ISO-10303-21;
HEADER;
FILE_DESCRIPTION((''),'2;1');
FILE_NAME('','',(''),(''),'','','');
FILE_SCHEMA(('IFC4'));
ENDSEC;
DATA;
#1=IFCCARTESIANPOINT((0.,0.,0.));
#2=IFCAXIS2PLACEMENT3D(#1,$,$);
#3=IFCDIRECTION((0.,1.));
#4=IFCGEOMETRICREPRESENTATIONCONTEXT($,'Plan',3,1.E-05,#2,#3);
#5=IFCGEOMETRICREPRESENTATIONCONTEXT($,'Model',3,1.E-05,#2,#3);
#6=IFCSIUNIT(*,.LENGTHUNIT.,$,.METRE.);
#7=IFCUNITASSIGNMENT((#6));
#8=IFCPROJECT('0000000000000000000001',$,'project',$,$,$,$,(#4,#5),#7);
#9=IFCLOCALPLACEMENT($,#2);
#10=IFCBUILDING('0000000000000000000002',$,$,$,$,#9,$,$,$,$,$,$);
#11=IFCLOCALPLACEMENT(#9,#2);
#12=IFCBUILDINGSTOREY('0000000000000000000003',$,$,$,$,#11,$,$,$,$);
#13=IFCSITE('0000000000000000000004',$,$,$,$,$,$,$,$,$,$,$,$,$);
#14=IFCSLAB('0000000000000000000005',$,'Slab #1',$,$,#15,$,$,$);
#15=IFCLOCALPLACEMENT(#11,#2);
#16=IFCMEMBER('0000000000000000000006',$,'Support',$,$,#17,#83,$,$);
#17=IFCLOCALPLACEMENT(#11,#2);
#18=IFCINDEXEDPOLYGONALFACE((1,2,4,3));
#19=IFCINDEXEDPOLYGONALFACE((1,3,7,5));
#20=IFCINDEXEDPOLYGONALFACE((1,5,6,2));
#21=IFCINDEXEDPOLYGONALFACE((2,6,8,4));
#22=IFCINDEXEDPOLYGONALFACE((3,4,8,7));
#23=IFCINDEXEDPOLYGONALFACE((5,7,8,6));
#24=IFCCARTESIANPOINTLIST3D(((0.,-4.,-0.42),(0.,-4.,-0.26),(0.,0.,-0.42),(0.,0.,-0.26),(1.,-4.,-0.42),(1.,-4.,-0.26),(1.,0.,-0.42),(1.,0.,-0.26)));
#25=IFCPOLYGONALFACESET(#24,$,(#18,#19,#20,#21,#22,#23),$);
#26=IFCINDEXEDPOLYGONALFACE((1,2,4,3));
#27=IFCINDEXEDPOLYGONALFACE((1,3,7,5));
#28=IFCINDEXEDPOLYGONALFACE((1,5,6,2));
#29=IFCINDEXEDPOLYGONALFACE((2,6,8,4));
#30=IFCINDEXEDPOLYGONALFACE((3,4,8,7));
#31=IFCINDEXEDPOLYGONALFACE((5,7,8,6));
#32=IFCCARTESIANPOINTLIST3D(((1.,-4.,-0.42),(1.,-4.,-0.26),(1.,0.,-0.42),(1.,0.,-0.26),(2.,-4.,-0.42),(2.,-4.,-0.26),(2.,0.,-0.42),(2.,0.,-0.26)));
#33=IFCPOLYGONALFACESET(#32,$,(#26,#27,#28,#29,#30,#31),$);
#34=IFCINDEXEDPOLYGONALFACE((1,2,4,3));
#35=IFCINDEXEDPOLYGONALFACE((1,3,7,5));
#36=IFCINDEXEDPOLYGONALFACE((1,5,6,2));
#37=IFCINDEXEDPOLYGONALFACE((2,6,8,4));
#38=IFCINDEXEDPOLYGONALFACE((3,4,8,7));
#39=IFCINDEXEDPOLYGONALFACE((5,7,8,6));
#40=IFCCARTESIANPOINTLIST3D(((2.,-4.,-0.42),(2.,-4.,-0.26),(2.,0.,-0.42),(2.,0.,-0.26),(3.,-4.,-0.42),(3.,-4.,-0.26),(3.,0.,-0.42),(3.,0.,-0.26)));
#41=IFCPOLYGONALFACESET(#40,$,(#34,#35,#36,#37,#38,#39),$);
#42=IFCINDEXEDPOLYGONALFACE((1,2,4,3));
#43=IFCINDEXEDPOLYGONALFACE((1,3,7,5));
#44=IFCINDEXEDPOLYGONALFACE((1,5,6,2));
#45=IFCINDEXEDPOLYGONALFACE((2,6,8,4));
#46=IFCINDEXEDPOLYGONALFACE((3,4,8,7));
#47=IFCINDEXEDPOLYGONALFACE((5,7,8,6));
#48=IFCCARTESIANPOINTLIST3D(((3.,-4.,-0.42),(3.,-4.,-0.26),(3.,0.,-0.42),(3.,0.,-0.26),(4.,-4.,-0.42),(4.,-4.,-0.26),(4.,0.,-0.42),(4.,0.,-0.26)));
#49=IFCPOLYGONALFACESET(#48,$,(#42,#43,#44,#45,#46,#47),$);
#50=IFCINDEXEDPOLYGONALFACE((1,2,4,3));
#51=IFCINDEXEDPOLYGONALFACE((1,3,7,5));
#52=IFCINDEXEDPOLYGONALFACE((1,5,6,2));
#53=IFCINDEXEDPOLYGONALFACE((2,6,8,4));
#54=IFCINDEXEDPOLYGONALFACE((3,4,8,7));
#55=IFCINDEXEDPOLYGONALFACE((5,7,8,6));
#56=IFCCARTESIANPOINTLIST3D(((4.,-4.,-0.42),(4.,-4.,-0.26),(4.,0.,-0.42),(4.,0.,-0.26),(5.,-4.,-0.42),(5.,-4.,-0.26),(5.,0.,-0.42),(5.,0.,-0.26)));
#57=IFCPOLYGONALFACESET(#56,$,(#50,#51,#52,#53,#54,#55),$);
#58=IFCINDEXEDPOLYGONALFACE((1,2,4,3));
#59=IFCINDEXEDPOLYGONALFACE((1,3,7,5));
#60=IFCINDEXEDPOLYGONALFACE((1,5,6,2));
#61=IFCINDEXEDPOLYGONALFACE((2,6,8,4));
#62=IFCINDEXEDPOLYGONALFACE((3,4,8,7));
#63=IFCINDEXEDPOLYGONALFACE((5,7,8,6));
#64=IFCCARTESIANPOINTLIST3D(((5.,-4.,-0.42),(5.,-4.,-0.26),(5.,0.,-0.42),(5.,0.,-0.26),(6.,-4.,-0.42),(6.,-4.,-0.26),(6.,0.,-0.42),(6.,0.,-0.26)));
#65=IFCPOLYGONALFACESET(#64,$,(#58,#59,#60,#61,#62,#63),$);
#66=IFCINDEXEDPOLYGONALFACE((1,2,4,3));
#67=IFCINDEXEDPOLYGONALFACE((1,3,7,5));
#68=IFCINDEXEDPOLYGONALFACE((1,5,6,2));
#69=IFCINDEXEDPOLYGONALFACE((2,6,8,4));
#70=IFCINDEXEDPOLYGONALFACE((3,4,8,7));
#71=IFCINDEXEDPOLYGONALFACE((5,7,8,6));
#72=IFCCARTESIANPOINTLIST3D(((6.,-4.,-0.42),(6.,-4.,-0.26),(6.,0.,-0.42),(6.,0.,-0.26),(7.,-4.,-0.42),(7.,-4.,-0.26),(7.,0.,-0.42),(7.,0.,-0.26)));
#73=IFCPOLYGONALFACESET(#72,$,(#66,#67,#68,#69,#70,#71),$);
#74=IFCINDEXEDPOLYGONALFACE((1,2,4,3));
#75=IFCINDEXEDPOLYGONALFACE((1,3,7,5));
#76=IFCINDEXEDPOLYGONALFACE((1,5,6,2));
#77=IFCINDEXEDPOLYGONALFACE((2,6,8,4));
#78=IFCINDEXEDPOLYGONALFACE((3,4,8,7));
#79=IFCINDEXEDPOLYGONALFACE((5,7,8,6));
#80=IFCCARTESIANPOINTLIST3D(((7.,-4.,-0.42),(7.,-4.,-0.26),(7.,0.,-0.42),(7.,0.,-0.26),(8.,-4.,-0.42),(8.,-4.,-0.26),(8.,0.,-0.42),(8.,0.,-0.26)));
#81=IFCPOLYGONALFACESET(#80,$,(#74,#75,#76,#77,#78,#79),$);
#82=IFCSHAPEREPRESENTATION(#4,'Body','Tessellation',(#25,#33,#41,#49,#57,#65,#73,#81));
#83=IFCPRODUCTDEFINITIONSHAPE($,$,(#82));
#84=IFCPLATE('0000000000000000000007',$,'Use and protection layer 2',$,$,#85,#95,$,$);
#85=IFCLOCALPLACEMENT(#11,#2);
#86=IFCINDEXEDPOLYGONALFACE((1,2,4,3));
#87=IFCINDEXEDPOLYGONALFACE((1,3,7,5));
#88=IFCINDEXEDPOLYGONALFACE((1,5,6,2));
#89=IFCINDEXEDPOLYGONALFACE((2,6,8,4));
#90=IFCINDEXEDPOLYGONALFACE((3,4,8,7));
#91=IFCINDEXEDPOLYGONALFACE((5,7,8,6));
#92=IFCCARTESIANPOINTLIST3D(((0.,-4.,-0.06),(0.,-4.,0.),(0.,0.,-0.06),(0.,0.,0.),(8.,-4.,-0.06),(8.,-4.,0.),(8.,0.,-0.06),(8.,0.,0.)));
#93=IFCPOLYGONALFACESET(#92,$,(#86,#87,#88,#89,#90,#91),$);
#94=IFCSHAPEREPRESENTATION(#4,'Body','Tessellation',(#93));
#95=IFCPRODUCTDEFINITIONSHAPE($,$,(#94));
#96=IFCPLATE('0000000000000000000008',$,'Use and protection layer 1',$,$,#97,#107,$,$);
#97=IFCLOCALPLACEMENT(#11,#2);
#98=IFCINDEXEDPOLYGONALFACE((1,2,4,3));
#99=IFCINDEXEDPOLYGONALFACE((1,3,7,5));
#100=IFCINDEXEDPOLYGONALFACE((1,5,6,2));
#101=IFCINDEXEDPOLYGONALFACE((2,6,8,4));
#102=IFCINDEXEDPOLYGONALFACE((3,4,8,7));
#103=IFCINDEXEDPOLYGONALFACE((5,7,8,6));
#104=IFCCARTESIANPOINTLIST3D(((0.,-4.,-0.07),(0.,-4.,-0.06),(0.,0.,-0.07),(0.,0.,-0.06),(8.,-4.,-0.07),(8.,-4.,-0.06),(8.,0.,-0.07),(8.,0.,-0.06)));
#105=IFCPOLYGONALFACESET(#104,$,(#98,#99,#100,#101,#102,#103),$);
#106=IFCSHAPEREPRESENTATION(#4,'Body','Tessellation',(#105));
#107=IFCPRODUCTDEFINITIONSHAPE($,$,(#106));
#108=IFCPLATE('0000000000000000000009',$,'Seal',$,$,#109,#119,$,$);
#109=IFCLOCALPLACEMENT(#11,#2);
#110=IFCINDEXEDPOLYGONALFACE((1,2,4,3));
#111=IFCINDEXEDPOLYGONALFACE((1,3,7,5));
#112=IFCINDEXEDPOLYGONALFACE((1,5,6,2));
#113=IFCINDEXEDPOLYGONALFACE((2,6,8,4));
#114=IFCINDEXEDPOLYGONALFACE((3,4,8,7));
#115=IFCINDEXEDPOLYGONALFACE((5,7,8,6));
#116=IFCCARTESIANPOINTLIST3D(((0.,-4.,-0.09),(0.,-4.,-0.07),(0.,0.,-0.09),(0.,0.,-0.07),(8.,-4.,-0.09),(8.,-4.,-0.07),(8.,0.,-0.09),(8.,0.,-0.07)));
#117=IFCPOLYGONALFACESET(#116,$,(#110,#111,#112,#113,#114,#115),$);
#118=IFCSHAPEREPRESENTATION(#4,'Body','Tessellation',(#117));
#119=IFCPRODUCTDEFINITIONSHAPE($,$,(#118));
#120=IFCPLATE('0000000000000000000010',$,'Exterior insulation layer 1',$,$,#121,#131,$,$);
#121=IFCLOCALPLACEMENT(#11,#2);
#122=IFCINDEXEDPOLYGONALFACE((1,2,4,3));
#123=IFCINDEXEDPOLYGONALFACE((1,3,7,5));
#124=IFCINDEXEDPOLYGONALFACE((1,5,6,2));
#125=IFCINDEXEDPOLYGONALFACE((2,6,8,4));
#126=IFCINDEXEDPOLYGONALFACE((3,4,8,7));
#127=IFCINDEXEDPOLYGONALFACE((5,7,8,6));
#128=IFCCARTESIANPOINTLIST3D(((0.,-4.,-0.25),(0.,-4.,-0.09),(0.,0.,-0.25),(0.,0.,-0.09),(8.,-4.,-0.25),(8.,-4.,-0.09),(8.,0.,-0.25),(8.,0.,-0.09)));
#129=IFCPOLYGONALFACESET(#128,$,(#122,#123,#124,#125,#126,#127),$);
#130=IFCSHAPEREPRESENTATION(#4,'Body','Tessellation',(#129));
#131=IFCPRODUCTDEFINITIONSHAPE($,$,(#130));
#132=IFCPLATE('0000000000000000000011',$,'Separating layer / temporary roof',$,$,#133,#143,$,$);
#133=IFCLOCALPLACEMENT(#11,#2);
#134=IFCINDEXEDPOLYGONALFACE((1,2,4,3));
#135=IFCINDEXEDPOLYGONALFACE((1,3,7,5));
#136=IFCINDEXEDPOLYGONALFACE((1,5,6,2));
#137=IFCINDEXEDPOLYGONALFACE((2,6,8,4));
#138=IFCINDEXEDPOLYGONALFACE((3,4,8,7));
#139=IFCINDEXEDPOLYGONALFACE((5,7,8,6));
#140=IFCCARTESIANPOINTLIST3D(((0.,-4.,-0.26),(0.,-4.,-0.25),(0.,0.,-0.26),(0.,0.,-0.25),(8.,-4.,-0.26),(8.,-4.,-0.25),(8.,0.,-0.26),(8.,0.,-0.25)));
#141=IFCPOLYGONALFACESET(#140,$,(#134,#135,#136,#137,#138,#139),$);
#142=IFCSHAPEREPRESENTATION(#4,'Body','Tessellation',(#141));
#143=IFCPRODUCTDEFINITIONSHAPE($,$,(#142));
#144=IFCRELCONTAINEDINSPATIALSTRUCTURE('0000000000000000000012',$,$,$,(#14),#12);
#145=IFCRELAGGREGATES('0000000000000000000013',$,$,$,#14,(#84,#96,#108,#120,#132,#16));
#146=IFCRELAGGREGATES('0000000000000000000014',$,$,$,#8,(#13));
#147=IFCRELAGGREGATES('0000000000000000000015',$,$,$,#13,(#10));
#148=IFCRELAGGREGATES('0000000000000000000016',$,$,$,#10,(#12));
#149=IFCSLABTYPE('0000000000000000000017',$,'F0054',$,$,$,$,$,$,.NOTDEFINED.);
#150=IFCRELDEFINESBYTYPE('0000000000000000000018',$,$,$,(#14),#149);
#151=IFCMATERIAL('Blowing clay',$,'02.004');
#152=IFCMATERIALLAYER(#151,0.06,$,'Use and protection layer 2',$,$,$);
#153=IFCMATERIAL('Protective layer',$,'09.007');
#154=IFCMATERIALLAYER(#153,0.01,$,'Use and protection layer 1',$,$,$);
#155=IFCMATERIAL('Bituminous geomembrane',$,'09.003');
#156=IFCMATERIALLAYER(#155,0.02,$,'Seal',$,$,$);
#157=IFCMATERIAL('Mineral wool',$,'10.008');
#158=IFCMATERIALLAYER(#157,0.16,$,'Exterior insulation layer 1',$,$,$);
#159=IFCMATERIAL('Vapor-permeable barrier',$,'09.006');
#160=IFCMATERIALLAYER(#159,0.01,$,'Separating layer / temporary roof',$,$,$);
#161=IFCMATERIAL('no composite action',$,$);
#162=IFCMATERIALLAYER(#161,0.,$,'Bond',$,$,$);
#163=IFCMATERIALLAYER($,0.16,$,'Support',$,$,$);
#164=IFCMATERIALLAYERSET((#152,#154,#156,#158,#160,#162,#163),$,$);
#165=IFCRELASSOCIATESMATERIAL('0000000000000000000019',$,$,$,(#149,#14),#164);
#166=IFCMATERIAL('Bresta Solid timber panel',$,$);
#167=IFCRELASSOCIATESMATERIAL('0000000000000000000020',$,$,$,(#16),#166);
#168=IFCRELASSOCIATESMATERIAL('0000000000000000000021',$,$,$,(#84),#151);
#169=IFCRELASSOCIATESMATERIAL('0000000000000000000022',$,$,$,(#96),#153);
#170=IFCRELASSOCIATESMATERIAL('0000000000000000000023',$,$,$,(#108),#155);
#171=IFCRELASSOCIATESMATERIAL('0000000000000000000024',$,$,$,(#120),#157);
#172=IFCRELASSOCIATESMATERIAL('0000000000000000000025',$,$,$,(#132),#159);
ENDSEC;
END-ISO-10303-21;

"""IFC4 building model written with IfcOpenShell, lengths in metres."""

from ifc_helpers import new_model, si_unit, direction, frame, frame_2d, origin, origin_with_axes, place, context, project, spatial, rectangle, extrude, material, layer, layer_set, type_object, element, aggregate, save


model = new_model("IFC4")

# Units and contexts
plan_context = context("Plan", 3, precision=1e-05, world=origin(), true_north=direction((0.0, 1.0)))
model_context = context("Model", 3, precision=1e-05, world=origin(), true_north=direction((0.0, 1.0)))
ifc_project = project(units=[si_unit("LENGTHUNIT", "METRE")], contexts=[plan_context, model_context])

# Site, building, storey
site = spatial("IfcSite", under=ifc_project)
building_placement = place(None, origin())
building = spatial("IfcBuilding", under=site, at=building_placement)
storey_placement = place(building_placement, origin())
storey = spatial("IfcBuildingStorey", under=building, at=storey_placement)

# Slab, member, plates
ifc_material_1 = material(Name="Blowing clay", Category="02.004")
ifc_layer_1 = layer(ifc_material_1, 0.06, Name="Use and protection layer 2")
ifc_material_2 = material(Name="Protective layer", Category="09.007")
ifc_layer_2 = layer(ifc_material_2, 0.01, Name="Use and protection layer 1")
ifc_material_3 = material(Name="Bituminous geomembrane", Category="09.003")
ifc_layer_3 = layer(ifc_material_3, 0.02, Name="Seal")
ifc_material_4 = material(Name="Mineral wool", Category="10.008")
ifc_layer_4 = layer(ifc_material_4, 0.16, Name="Exterior insulation layer 1")
ifc_material_5 = material(Name="Vapor-permeable barrier", Category="09.006")
ifc_layer_5 = layer(ifc_material_5, 0.01, Name="Separating layer / temporary roof")
ifc_material_6 = material(Name="no composite action")
ifc_layer_6 = layer(ifc_material_6, 0.0, Name="Bond")
ifc_layer_7 = layer(None, 0.16, Name="Support")
ifc_layer_set = layer_set([ifc_layer_1, ifc_layer_2, ifc_layer_3, ifc_layer_4, ifc_layer_5, ifc_layer_6, ifc_layer_7])
slab_type = type_object("IfcSlabType", Name="F0054", PredefinedType="NOTDEFINED", material=ifc_layer_set)
slab_placement = place(None, frame((0.0, 0.0, 0.0), z_axis=(0.0, 0.0, -1.0), x_axis=(1.0, 0.0, 0.0)))
slab = element("IfcSlab", 1, at=slab_placement, inside=storey, type_object=slab_type, material=ifc_layer_set, Name="Slab #1")
ifc_material_7 = material(Name="Bresta Solid timber panel")
member_placement = place(slab_placement, origin())
member = element("IfcMember", 2, at=member_placement, material=ifc_material_7, Name="Support", context=plan_context, shape_type="SweptSolid", body=[
    extrude(rectangle(XDim=1.0, YDim=0.16, at=frame_2d((0.5, 0.08), x_axis=(1.0, 0.0))), frame((0.0, 4.0, 0.26), z_axis=(0.0, -1.0, 0.0), x_axis=(1.0, 0.0, 0.0)), (0.0, 0.0, 1.0), 4.0),
    extrude(rectangle(XDim=1.0, YDim=0.16, at=frame_2d((0.5, 0.08), x_axis=(1.0, 0.0))), frame((1.0, 4.0, 0.26), z_axis=(0.0, -1.0, 0.0), x_axis=(1.0, 0.0, 0.0)), (0.0, 0.0, 1.0), 4.0),
    extrude(rectangle(XDim=1.0, YDim=0.16, at=frame_2d((0.5, 0.08), x_axis=(1.0, 0.0))), frame((2.0, 4.0, 0.26), z_axis=(0.0, -1.0, 0.0), x_axis=(1.0, 0.0, 0.0)), (0.0, 0.0, 1.0), 4.0),
    extrude(rectangle(XDim=1.0, YDim=0.16, at=frame_2d((0.5, 0.08), x_axis=(1.0, 0.0))), frame((3.0, 4.0, 0.26), z_axis=(0.0, -1.0, 0.0), x_axis=(1.0, 0.0, 0.0)), (0.0, 0.0, 1.0), 4.0),
    extrude(rectangle(XDim=1.0, YDim=0.16, at=frame_2d((0.5, 0.08), x_axis=(1.0, 0.0))), frame((4.0, 4.0, 0.26), z_axis=(0.0, -1.0, 0.0), x_axis=(1.0, 0.0, 0.0)), (0.0, 0.0, 1.0), 4.0),
    extrude(rectangle(XDim=1.0, YDim=0.16, at=frame_2d((0.5, 0.08), x_axis=(1.0, 0.0))), frame((5.0, 4.0, 0.26), z_axis=(0.0, -1.0, 0.0), x_axis=(1.0, 0.0, 0.0)), (0.0, 0.0, 1.0), 4.0),
    extrude(rectangle(XDim=1.0, YDim=0.16, at=frame_2d((0.5, 0.08), x_axis=(1.0, 0.0))), frame((6.0, 4.0, 0.26), z_axis=(0.0, -1.0, 0.0), x_axis=(1.0, 0.0, 0.0)), (0.0, 0.0, 1.0), 4.0),
    extrude(rectangle(XDim=1.0, YDim=0.16, at=frame_2d((0.5, 0.08), x_axis=(1.0, 0.0))), frame((7.0, 4.0, 0.26), z_axis=(0.0, -1.0, 0.0), x_axis=(1.0, 0.0, 0.0)), (0.0, 0.0, 1.0), 4.0),
])
plate_1_placement = place(slab_placement, origin())
plate_1 = element("IfcPlate", 3, at=plate_1_placement, material=ifc_material_1, Name="Use and protection layer 2", context=plan_context, shape_type="SweptSolid", body=[
    extrude(rectangle(XDim=8.0, YDim=4.0, at=frame_2d((4.0, 2.0), x_axis=(1.0, 0.0))), origin_with_axes(), (0.0, 0.0, 1.0), 0.06),
])
plate_2_placement = place(slab_placement, origin())
plate_2 = element("IfcPlate", 4, at=plate_2_placement, material=ifc_material_2, Name="Use and protection layer 1", context=plan_context, shape_type="SweptSolid", body=[
    extrude(rectangle(XDim=8.0, YDim=4.0, at=frame_2d((4.0, 2.0), x_axis=(1.0, 0.0))), frame((0.0, 0.0, 0.06), z_axis=(0.0, 0.0, 1.0), x_axis=(1.0, 0.0, 0.0)), (0.0, 0.0, 1.0), 0.01),
])
plate_3_placement = place(slab_placement, origin())
plate_3 = element("IfcPlate", 5, at=plate_3_placement, material=ifc_material_3, Name="Seal", context=plan_context, shape_type="SweptSolid", body=[
    extrude(rectangle(XDim=8.0, YDim=4.0, at=frame_2d((4.0, 2.0), x_axis=(1.0, 0.0))), frame((0.0, 0.0, 0.07), z_axis=(0.0, 0.0, 1.0), x_axis=(1.0, 0.0, 0.0)), (0.0, 0.0, 1.0), 0.02),
])
plate_4_placement = place(slab_placement, origin())
plate_4 = element("IfcPlate", 6, at=plate_4_placement, material=ifc_material_4, Name="Exterior insulation layer 1", context=plan_context, shape_type="SweptSolid", body=[
    extrude(rectangle(XDim=8.0, YDim=4.0, at=frame_2d((4.0, 2.0), x_axis=(1.0, 0.0))), frame((0.0, 0.0, 0.09), z_axis=(0.0, 0.0, 1.0), x_axis=(1.0, 0.0, 0.0)), (0.0, 0.0, 1.0), 0.16),
])
plate_5_placement = place(slab_placement, origin())
plate_5 = element("IfcPlate", 7, at=plate_5_placement, material=ifc_material_5, Name="Separating layer / temporary roof", context=plan_context, shape_type="SweptSolid", body=[
    extrude(rectangle(XDim=8.0, YDim=4.0, at=frame_2d((4.0, 2.0), x_axis=(1.0, 0.0))), frame((0.0, 0.0, 0.25), z_axis=(0.0, 0.0, 1.0), x_axis=(1.0, 0.0, 0.0)), (0.0, 0.0, 1.0), 0.01),
])
aggregate(slab, [plate_1, plate_2, plate_3, plate_4, plate_5, member])

save(model, "model.ifc")
